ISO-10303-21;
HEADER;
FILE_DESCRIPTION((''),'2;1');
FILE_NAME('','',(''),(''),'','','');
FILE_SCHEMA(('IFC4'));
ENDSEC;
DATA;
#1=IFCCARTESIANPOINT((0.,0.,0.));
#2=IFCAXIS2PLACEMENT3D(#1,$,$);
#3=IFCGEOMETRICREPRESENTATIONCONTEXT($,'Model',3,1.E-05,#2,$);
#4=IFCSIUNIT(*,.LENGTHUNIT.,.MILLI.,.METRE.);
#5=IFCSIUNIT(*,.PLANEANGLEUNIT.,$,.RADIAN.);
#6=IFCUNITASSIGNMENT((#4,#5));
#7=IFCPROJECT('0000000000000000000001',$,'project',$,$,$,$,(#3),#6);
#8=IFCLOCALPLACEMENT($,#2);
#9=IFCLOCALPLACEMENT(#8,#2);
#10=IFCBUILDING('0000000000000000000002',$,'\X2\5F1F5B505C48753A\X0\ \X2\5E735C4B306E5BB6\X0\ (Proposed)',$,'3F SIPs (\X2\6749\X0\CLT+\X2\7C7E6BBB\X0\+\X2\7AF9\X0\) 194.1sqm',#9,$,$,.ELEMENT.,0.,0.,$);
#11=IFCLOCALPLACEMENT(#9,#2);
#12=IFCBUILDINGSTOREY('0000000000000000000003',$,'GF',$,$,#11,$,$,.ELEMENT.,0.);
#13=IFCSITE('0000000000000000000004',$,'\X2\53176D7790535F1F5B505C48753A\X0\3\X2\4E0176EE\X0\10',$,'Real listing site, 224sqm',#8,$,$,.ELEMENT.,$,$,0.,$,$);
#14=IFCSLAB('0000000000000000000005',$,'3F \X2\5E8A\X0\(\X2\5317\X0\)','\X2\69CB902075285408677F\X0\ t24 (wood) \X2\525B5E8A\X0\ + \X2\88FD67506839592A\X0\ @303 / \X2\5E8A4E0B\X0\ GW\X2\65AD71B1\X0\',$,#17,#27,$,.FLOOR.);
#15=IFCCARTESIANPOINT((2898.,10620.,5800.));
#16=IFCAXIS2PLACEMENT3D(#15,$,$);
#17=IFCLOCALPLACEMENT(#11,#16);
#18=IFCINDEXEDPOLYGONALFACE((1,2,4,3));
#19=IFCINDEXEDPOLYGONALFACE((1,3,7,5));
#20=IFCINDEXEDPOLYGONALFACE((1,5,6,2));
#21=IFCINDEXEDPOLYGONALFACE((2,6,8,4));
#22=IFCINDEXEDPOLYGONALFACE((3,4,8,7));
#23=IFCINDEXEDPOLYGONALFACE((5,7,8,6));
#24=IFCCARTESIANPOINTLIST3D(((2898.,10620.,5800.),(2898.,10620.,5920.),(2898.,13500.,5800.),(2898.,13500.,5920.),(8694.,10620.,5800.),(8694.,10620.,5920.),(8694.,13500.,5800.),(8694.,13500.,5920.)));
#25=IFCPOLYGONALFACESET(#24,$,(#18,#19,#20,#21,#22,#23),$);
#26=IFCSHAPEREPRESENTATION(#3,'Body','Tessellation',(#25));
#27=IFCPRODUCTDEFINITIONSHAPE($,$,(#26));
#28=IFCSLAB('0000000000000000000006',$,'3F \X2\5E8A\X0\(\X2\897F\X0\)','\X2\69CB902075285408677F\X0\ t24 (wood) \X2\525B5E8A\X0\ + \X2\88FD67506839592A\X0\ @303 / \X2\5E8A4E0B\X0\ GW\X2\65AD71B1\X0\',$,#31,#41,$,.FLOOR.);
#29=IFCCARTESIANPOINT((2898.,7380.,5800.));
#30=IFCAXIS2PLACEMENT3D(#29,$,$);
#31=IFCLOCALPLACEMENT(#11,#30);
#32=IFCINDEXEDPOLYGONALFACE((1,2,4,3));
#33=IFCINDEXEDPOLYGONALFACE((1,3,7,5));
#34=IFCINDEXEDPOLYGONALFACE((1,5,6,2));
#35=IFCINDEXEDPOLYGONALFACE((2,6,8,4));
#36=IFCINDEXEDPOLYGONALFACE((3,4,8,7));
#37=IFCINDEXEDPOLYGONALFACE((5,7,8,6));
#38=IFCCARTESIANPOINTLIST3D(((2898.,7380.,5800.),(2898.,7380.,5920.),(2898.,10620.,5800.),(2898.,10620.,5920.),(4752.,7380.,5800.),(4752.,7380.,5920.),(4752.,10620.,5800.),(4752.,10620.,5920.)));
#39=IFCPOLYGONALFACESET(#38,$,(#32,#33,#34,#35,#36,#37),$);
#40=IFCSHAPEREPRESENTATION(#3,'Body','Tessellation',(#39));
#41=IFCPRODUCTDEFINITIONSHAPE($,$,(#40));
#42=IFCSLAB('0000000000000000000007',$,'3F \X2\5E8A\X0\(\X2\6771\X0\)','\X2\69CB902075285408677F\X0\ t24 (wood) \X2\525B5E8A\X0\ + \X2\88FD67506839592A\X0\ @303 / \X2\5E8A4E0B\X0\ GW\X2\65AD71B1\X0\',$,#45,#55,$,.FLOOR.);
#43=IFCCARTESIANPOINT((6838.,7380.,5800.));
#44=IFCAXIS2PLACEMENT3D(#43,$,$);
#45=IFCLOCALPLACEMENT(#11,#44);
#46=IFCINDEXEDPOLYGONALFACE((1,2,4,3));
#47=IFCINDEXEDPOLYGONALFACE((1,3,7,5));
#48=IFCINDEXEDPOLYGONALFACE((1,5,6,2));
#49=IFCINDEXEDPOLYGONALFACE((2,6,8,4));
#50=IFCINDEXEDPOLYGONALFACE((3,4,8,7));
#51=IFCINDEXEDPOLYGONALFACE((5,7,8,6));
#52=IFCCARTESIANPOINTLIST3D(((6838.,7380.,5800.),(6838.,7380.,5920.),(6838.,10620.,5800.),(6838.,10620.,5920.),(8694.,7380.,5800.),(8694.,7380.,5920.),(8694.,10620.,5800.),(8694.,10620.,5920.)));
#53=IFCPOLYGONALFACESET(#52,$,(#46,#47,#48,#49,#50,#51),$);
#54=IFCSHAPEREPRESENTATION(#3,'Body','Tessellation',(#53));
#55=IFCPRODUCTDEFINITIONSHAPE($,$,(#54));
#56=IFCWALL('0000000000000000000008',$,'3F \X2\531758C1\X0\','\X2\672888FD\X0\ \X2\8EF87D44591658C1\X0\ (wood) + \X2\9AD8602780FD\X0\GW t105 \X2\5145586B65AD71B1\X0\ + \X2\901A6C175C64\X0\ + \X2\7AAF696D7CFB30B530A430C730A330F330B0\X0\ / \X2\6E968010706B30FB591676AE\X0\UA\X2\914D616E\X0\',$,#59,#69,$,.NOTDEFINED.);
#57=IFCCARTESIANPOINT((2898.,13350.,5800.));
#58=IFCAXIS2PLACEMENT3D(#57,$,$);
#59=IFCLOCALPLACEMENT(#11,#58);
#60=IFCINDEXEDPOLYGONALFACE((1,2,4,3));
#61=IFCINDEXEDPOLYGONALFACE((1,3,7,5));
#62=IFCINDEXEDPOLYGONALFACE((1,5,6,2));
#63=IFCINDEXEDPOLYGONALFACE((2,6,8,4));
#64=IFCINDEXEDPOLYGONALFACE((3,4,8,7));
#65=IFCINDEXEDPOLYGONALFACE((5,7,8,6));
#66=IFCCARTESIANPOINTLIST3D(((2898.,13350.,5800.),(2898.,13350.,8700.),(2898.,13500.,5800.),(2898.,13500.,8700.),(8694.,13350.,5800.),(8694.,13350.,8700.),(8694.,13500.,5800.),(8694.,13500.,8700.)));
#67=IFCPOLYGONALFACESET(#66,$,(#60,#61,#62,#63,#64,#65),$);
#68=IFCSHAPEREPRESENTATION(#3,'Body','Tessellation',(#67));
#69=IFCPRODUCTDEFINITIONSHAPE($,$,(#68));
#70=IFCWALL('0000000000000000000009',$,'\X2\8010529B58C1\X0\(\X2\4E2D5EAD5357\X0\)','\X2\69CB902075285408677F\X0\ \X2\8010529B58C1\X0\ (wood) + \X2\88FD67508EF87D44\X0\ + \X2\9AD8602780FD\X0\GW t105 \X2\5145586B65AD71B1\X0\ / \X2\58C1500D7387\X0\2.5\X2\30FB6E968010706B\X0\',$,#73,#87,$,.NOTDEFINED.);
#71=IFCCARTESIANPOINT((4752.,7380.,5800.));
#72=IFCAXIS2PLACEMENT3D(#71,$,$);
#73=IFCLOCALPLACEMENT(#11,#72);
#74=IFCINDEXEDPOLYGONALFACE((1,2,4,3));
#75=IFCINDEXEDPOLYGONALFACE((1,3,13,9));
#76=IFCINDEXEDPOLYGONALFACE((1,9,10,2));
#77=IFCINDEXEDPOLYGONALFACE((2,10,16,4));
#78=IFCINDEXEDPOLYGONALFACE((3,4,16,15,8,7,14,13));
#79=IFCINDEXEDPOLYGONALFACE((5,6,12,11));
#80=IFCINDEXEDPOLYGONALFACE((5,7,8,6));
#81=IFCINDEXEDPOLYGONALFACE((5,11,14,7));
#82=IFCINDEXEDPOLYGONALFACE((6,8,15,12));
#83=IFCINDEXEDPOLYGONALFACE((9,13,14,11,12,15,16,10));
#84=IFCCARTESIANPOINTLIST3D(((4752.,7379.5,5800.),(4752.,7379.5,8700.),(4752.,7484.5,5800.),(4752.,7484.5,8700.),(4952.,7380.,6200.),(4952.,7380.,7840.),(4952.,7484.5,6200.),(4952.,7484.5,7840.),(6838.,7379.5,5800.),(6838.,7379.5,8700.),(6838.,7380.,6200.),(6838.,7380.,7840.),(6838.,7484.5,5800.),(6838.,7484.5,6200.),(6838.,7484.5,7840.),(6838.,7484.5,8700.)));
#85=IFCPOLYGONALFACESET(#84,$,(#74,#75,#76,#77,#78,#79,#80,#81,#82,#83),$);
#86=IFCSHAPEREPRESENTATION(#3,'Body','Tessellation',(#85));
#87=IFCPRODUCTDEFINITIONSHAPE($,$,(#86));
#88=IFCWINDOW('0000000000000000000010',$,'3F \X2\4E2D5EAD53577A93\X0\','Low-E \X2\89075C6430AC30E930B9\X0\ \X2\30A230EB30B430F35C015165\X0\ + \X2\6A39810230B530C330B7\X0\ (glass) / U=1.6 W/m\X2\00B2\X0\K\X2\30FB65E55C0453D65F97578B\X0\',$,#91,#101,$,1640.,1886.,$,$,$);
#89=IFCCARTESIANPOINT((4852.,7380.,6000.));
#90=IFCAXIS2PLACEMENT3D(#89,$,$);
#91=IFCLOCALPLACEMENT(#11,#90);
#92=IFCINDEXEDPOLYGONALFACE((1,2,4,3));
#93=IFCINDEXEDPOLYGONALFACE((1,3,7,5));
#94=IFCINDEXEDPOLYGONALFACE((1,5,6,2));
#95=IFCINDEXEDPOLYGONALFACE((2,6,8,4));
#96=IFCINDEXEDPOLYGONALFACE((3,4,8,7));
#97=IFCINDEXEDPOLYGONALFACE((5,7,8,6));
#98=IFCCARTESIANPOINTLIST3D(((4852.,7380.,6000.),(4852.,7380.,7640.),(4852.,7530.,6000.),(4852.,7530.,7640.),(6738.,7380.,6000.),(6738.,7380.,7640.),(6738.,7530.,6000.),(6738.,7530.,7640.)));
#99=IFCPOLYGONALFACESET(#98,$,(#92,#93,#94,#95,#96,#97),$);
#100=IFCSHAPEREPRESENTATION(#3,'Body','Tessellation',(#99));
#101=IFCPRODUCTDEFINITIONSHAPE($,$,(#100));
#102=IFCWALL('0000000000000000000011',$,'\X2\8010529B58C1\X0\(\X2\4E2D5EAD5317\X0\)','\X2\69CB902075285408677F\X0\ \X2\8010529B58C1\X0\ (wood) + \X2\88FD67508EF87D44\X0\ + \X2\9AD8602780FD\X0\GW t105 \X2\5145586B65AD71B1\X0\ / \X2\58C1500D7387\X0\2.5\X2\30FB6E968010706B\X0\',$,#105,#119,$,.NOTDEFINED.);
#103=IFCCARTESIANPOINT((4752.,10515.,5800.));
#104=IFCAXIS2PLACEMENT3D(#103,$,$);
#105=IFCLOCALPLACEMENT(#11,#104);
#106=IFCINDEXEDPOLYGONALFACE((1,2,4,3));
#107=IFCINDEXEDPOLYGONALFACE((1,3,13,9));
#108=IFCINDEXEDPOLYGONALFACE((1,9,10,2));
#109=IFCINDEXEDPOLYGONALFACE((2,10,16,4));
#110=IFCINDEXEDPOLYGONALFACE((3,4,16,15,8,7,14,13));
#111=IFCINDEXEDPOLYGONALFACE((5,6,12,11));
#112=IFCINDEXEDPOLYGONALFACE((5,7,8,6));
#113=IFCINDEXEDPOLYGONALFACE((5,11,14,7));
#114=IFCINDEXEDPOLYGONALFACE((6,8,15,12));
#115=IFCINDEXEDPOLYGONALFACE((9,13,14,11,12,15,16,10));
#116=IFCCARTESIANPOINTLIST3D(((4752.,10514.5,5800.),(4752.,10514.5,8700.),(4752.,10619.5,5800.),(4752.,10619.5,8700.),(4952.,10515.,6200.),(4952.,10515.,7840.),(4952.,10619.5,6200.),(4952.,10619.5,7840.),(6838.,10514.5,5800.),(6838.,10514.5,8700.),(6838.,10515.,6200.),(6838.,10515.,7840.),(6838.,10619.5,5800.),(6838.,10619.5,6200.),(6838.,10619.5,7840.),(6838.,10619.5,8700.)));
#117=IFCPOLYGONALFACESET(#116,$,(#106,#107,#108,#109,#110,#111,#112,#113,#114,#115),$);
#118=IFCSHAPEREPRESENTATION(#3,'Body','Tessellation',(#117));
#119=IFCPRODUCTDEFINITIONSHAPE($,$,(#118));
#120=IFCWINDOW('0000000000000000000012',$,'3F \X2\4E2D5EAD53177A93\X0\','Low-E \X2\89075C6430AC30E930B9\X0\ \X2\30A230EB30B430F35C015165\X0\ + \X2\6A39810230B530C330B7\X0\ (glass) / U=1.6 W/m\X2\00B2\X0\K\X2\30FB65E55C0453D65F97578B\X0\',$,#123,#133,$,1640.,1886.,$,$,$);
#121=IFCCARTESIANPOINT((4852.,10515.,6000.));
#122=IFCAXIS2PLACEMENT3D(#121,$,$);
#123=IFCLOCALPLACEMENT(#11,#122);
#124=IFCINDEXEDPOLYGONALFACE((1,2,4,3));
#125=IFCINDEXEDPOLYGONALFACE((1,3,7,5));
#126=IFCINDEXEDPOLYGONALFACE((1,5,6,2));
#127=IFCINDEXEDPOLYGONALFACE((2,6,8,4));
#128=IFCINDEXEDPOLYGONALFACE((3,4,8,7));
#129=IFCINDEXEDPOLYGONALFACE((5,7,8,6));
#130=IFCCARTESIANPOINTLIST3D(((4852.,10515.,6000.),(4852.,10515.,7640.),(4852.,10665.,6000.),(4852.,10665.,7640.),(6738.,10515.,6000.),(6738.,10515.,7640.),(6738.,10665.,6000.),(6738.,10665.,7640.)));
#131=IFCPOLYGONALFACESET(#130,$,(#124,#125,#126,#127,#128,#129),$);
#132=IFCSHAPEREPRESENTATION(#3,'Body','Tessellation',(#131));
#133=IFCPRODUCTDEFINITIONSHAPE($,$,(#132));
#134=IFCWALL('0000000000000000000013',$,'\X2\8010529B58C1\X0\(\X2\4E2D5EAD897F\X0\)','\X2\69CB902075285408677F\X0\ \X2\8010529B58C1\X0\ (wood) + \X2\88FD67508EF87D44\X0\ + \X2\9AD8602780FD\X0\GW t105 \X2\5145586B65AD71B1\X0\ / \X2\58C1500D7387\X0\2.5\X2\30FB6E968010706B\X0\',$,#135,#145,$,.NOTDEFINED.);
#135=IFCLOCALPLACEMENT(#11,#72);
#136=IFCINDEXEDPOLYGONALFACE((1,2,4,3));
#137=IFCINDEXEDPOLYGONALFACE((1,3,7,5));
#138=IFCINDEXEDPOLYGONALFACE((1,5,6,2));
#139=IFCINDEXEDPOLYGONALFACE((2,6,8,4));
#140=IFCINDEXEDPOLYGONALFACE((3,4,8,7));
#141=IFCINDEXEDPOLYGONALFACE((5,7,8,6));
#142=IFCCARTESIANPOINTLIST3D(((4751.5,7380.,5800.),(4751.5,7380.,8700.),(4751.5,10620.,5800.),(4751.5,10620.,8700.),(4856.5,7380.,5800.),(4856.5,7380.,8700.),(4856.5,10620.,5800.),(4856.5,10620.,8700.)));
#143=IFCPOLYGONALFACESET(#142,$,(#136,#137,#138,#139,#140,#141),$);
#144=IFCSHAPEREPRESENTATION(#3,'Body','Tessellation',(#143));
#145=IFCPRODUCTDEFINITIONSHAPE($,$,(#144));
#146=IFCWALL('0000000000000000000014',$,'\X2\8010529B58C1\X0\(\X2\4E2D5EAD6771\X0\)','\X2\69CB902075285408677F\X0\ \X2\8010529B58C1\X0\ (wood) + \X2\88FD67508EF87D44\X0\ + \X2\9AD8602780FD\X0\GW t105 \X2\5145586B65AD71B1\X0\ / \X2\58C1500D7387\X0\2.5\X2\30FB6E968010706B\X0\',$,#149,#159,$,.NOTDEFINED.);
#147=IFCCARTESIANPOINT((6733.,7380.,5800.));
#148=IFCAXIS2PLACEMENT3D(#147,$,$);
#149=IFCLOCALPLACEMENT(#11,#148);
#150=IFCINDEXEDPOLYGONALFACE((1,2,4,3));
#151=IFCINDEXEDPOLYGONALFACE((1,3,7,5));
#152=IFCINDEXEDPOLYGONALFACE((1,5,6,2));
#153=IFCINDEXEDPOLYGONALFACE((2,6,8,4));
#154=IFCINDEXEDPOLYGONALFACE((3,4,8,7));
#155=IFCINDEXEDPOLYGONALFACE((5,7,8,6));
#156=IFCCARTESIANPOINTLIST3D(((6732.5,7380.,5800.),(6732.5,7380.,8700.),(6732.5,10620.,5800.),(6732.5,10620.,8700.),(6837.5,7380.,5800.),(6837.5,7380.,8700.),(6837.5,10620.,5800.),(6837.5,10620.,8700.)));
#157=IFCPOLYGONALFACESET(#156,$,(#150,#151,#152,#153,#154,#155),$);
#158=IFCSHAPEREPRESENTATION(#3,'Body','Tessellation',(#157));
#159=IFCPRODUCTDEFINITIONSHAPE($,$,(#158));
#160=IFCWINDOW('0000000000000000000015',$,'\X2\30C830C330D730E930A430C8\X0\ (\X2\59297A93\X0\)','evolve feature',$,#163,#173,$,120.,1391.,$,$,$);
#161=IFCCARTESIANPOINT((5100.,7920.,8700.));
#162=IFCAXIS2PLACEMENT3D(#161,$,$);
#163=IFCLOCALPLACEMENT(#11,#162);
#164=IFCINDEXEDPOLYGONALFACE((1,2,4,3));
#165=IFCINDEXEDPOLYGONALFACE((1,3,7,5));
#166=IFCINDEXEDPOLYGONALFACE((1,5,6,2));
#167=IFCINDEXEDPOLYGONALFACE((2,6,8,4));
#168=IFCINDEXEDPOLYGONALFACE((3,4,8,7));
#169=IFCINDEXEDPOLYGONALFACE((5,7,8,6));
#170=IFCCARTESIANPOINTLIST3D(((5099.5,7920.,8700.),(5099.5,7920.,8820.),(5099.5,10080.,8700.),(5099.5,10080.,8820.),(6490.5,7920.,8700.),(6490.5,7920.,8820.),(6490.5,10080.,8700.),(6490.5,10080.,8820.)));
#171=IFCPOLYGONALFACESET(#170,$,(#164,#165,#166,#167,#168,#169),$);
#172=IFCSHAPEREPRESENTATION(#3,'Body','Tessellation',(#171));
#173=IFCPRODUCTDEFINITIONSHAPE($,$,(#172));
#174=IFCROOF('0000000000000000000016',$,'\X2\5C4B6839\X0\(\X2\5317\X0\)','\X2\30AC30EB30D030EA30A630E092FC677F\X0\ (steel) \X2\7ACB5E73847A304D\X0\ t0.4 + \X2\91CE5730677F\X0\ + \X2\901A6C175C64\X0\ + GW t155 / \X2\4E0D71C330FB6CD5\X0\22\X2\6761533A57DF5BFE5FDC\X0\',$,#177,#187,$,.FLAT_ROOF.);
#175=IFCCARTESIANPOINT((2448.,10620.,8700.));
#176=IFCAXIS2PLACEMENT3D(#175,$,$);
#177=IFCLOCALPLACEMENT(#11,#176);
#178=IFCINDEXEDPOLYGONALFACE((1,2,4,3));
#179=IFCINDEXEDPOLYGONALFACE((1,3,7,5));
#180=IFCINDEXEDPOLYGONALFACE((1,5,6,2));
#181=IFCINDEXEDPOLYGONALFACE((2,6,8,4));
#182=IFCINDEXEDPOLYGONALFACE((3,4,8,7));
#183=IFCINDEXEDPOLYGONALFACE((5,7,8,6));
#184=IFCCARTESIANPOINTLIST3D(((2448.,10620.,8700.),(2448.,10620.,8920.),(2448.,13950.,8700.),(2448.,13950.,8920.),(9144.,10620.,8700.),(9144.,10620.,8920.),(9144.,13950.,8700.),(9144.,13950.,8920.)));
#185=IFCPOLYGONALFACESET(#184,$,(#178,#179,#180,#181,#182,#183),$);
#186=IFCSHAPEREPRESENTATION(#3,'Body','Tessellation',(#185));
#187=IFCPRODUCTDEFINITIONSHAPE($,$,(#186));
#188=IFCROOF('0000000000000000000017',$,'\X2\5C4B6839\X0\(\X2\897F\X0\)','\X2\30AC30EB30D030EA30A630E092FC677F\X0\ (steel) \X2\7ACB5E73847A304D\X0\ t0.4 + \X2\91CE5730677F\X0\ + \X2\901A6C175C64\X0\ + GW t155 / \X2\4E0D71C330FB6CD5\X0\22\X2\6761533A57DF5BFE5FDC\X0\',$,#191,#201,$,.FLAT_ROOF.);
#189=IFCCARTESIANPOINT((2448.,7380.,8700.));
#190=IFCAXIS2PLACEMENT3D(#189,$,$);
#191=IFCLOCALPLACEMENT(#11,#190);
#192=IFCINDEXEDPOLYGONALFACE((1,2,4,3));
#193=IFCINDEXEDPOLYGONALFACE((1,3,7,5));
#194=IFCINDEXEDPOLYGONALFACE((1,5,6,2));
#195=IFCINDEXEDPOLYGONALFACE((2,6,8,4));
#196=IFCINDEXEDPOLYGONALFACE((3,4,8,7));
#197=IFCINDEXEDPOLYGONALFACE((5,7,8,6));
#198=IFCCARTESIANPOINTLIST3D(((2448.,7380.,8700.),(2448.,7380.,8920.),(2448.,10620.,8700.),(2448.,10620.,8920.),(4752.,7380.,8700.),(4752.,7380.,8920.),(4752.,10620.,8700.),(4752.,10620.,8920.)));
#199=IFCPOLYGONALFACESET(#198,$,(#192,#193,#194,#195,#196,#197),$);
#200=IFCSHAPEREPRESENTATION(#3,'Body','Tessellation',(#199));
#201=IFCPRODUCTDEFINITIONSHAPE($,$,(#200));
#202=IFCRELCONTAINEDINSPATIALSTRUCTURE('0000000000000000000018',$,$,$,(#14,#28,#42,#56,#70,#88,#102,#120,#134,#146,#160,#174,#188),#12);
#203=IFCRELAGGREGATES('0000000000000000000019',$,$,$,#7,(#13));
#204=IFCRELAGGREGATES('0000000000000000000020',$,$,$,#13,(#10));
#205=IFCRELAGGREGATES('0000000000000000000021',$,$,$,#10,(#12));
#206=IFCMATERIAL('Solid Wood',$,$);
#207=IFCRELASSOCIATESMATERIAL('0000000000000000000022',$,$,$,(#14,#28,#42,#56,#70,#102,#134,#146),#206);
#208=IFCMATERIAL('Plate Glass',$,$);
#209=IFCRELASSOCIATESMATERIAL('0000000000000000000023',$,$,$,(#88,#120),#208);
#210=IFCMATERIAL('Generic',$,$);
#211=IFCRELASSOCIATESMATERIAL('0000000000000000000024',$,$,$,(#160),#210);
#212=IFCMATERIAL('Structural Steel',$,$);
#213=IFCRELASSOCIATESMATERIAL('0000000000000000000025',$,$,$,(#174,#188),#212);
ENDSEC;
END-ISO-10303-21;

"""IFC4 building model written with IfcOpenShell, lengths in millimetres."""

from ifc_helpers import new_model, si_unit, frame, frame_2d, origin, place, context, project, spatial, rectangle, extrude, material, element, fill, save


model = new_model("IFC4")

# Units and contexts
model_context = context("Model", 3, precision=1e-05, world=origin())
ifc_project = project(units=[si_unit("LENGTHUNIT", "METRE", prefix="MILLI"), si_unit("PLANEANGLEUNIT", "RADIAN")], contexts=[model_context])

# Site, building, storey
site_placement = place(None, origin())
site = spatial("IfcSite", under=ifc_project, at=site_placement, Name="北海道弟子屈町3丁目10", ObjectType="Real listing site, 224sqm", CompositionType="ELEMENT", RefElevation=0.0)
building_placement = place(site_placement, origin())
building = spatial("IfcBuilding", under=site, at=building_placement, Name="弟子屈町 平屋の家 (Proposed)", ObjectType="3F SIPs (杉CLT+籾殻+竹) 194.1sqm", CompositionType="ELEMENT", ElevationOfRefHeight=0.0, ElevationOfTerrain=0.0)
storey_placement = place(building_placement, origin())
storey = spatial("IfcBuildingStorey", under=building, at=storey_placement, Name="GF", CompositionType="ELEMENT", Elevation=0.0)

# Slabs
ifc_material_1 = material(Name="Solid Wood")
slab_1_placement = place(storey_placement, frame((2898.0, 10620.0, 5800.0)))
element("IfcSlab", 1, at=slab_1_placement, inside=storey, material=ifc_material_1, Name="3F 床(北)", Description="構造用合板 t24 (wood) 剛床 + 製材根太 @303 / 床下 GW断熱", PredefinedType="FLOOR", context=model_context, shape_type="SweptSolid", body=[
    extrude(rectangle(XDim=5796.0, YDim=2880.0, at=frame_2d((2898.0, 1440.0))), frame((2898.0, 10620.0, 5800.0)), (0.0, 0.0, 1.0), 120.0),
])
slab_2_placement = place(storey_placement, frame((2898.0, 7380.0, 5800.0)))
element("IfcSlab", 2, at=slab_2_placement, inside=storey, material=ifc_material_1, Name="3F 床(西)", Description="構造用合板 t24 (wood) 剛床 + 製材根太 @303 / 床下 GW断熱", PredefinedType="FLOOR", context=model_context, shape_type="SweptSolid", body=[
    extrude(rectangle(XDim=1854.0, YDim=3240.0, at=frame_2d((927.0, 1620.0))), frame((2898.0, 7380.0, 5800.0)), (0.0, 0.0, 1.0), 120.0),
])
slab_3_placement = place(storey_placement, frame((6838.0, 7380.0, 5800.0)))
element("IfcSlab", 3, at=slab_3_placement, inside=storey, material=ifc_material_1, Name="3F 床(東)", Description="構造用合板 t24 (wood) 剛床 + 製材根太 @303 / 床下 GW断熱", PredefinedType="FLOOR", context=model_context, shape_type="SweptSolid", body=[
    extrude(rectangle(XDim=1856.0, YDim=3240.0, at=frame_2d((928.0, 1620.0))), frame((6838.0, 7380.0, 5800.0)), (0.0, 0.0, 1.0), 120.0),
])

# Wall
wall_1_placement = place(storey_placement, frame((2898.0, 13350.0, 5800.0)))
element("IfcWall", 4, at=wall_1_placement, inside=storey, material=ifc_material_1, Name="3F 北壁", Description="木製 軸組外壁 (wood) + 高性能GW t105 充填断熱 + 通気層 + 窯業系サイディング / 準耐火・外皮UA配慮", PredefinedType="NOTDEFINED", context=model_context, shape_type="SweptSolid", body=[
    extrude(rectangle(XDim=5796.0, YDim=150.0, at=frame_2d((2898.0, 75.0))), frame((2898.0, 13350.0, 5800.0)), (0.0, 0.0, 1.0), 2900.0),
])

# Walls, openings, windows
wall_2_placement = place(storey_placement, frame((4752.0, 7380.0, 5800.0)))
wall_2 = element("IfcWall", 5, at=wall_2_placement, inside=storey, material=ifc_material_1, Name="耐力壁(中庭南)", Description="構造用合板 耐力壁 (wood) + 製材軸組 + 高性能GW t105 充填断熱 / 壁倍率2.5・準耐火", PredefinedType="NOTDEFINED", context=model_context, shape_type="SweptSolid", body=[
    extrude(rectangle(XDim=2086.0, YDim=105.0, at=frame_2d((1043.0, 52.0))), frame((4752.0, 7380.0, 5800.0)), (0.0, 0.0, 1.0), 2900.0),
])
opening_1_placement = place(storey_placement, frame((4852.0, 7380.0, 6000.0)))
opening_1 = element("IfcOpeningElement", 6, at=opening_1_placement, cuts=wall_2, PredefinedType="NOTDEFINED", context=model_context, shape_type="SweptSolid", body=[
    extrude(rectangle(XDim=1886.0, YDim=150.0, at=frame_2d((943.0, 75.0))), frame((4852.0, 7380.0, 6000.0)), (0.0, 0.0, 1.0), 1640.0),
])
ifc_material_2 = material(Name="Plate Glass")
window_1_placement = place(storey_placement, frame((4852.0, 7380.0, 6000.0)))
window_1 = element("IfcWindow", 7, at=window_1_placement, inside=storey, material=ifc_material_2, Name="3F 中庭南窓", Description="Low-E 複層ガラス アルゴン封入 + 樹脂サッシ (glass) / U=1.6 W/m²K・日射取得型", OverallHeight=1640.0, OverallWidth=1886.0, context=model_context, shape_type="SweptSolid", body=[
    extrude(rectangle(XDim=1886.0, YDim=150.0, at=frame_2d((943.0, 75.0))), frame((4852.0, 7380.0, 6000.0)), (0.0, 0.0, 1.0), 1640.0),
])
fill(opening_1, window_1)
wall_3_placement = place(storey_placement, frame((4752.0, 10515.0, 5800.0)))
wall_3 = element("IfcWall", 8, at=wall_3_placement, inside=storey, material=ifc_material_1, Name="耐力壁(中庭北)", Description="構造用合板 耐力壁 (wood) + 製材軸組 + 高性能GW t105 充填断熱 / 壁倍率2.5・準耐火", PredefinedType="NOTDEFINED", context=model_context, shape_type="SweptSolid", body=[
    extrude(rectangle(XDim=2086.0, YDim=105.0, at=frame_2d((1043.0, 52.0))), frame((4752.0, 10515.0, 5800.0)), (0.0, 0.0, 1.0), 2900.0),
])
opening_2_placement = place(storey_placement, frame((4852.0, 10515.0, 6000.0)))
opening_2 = element("IfcOpeningElement", 9, at=opening_2_placement, cuts=wall_3, PredefinedType="NOTDEFINED", context=model_context, shape_type="SweptSolid", body=[
    extrude(rectangle(XDim=1886.0, YDim=150.0, at=frame_2d((943.0, 75.0))), frame((4852.0, 10515.0, 6000.0)), (0.0, 0.0, 1.0), 1640.0),
])
window_2_placement = place(storey_placement, frame((4852.0, 10515.0, 6000.0)))
window_2 = element("IfcWindow", 10, at=window_2_placement, inside=storey, material=ifc_material_2, Name="3F 中庭北窓", Description="Low-E 複層ガラス アルゴン封入 + 樹脂サッシ (glass) / U=1.6 W/m²K・日射取得型", OverallHeight=1640.0, OverallWidth=1886.0, context=model_context, shape_type="SweptSolid", body=[
    extrude(rectangle(XDim=1886.0, YDim=150.0, at=frame_2d((943.0, 75.0))), frame((4852.0, 10515.0, 6000.0)), (0.0, 0.0, 1.0), 1640.0),
])
fill(opening_2, window_2)

# Walls
wall_4_placement = place(storey_placement, frame((4752.0, 7380.0, 5800.0)))
element("IfcWall", 11, at=wall_4_placement, inside=storey, material=ifc_material_1, Name="耐力壁(中庭西)", Description="構造用合板 耐力壁 (wood) + 製材軸組 + 高性能GW t105 充填断熱 / 壁倍率2.5・準耐火", PredefinedType="NOTDEFINED", context=model_context, shape_type="SweptSolid", body=[
    extrude(rectangle(XDim=105.0, YDim=3240.0, at=frame_2d((52.0, 1620.0))), frame((4752.0, 7380.0, 5800.0)), (0.0, 0.0, 1.0), 2900.0),
])
wall_5_placement = place(storey_placement, frame((6733.0, 7380.0, 5800.0)))
element("IfcWall", 12, at=wall_5_placement, inside=storey, material=ifc_material_1, Name="耐力壁(中庭東)", Description="構造用合板 耐力壁 (wood) + 製材軸組 + 高性能GW t105 充填断熱 / 壁倍率2.5・準耐火", PredefinedType="NOTDEFINED", context=model_context, shape_type="SweptSolid", body=[
    extrude(rectangle(XDim=105.0, YDim=3240.0, at=frame_2d((52.0, 1620.0))), frame((6733.0, 7380.0, 5800.0)), (0.0, 0.0, 1.0), 2900.0),
])

# Window
ifc_material_3 = material(Name="Generic")
window_3_placement = place(storey_placement, frame((5100.0, 7920.0, 8700.0)))
element("IfcWindow", 13, at=window_3_placement, inside=storey, material=ifc_material_3, Name="トップライト (天窓)", Description="evolve feature", OverallHeight=120.0, OverallWidth=1391.0, context=model_context, shape_type="SweptSolid", body=[
    extrude(rectangle(XDim=1391.0, YDim=2160.0, at=frame_2d((695.0, 1080.0))), frame((5100.0, 7920.0, 8700.0)), (0.0, 0.0, 1.0), 120.0),
])

# Roofs
ifc_material_4 = material(Name="Structural Steel")
for number, where, name in (
    (14, (2448.0, 10620.0, 8700.0), "屋根(北)"),
):
    element("IfcRoof", number, at=place(storey_placement, frame(where)), inside=storey, material=ifc_material_4, Name=name, Description="ガルバリウム鋼板 (steel) 立平葺き t0.4 + 野地板 + 通気層 + GW t155 / 不燃・法22条区域対応", PredefinedType="FLAT_ROOF", context=model_context, shape_type="SweptSolid", body=[
        extrude(rectangle(XDim=6696.0, YDim=3330.0, at=frame_2d((3348.0, 1665.0))), frame((2448.0, 10620.0, 8700.0)), (0.0, 0.0, 1.0), 220.0),
    ])
roof_1_placement = place(storey_placement, frame((2448.0, 7380.0, 8700.0)))
element("IfcRoof", 15, at=roof_1_placement, inside=storey, material=ifc_material_4, Name="屋根(西)", Description="ガルバリウム鋼板 (steel) 立平葺き t0.4 + 野地板 + 通気層 + GW t155 / 不燃・法22条区域対応", PredefinedType="FLAT_ROOF", context=model_context, shape_type="SweptSolid", body=[
    extrude(rectangle(XDim=2304.0, YDim=3240.0, at=frame_2d((1152.0, 1620.0))), frame((2448.0, 7380.0, 8700.0)), (0.0, 0.0, 1.0), 220.0),
])

save(model, "model.ifc")
